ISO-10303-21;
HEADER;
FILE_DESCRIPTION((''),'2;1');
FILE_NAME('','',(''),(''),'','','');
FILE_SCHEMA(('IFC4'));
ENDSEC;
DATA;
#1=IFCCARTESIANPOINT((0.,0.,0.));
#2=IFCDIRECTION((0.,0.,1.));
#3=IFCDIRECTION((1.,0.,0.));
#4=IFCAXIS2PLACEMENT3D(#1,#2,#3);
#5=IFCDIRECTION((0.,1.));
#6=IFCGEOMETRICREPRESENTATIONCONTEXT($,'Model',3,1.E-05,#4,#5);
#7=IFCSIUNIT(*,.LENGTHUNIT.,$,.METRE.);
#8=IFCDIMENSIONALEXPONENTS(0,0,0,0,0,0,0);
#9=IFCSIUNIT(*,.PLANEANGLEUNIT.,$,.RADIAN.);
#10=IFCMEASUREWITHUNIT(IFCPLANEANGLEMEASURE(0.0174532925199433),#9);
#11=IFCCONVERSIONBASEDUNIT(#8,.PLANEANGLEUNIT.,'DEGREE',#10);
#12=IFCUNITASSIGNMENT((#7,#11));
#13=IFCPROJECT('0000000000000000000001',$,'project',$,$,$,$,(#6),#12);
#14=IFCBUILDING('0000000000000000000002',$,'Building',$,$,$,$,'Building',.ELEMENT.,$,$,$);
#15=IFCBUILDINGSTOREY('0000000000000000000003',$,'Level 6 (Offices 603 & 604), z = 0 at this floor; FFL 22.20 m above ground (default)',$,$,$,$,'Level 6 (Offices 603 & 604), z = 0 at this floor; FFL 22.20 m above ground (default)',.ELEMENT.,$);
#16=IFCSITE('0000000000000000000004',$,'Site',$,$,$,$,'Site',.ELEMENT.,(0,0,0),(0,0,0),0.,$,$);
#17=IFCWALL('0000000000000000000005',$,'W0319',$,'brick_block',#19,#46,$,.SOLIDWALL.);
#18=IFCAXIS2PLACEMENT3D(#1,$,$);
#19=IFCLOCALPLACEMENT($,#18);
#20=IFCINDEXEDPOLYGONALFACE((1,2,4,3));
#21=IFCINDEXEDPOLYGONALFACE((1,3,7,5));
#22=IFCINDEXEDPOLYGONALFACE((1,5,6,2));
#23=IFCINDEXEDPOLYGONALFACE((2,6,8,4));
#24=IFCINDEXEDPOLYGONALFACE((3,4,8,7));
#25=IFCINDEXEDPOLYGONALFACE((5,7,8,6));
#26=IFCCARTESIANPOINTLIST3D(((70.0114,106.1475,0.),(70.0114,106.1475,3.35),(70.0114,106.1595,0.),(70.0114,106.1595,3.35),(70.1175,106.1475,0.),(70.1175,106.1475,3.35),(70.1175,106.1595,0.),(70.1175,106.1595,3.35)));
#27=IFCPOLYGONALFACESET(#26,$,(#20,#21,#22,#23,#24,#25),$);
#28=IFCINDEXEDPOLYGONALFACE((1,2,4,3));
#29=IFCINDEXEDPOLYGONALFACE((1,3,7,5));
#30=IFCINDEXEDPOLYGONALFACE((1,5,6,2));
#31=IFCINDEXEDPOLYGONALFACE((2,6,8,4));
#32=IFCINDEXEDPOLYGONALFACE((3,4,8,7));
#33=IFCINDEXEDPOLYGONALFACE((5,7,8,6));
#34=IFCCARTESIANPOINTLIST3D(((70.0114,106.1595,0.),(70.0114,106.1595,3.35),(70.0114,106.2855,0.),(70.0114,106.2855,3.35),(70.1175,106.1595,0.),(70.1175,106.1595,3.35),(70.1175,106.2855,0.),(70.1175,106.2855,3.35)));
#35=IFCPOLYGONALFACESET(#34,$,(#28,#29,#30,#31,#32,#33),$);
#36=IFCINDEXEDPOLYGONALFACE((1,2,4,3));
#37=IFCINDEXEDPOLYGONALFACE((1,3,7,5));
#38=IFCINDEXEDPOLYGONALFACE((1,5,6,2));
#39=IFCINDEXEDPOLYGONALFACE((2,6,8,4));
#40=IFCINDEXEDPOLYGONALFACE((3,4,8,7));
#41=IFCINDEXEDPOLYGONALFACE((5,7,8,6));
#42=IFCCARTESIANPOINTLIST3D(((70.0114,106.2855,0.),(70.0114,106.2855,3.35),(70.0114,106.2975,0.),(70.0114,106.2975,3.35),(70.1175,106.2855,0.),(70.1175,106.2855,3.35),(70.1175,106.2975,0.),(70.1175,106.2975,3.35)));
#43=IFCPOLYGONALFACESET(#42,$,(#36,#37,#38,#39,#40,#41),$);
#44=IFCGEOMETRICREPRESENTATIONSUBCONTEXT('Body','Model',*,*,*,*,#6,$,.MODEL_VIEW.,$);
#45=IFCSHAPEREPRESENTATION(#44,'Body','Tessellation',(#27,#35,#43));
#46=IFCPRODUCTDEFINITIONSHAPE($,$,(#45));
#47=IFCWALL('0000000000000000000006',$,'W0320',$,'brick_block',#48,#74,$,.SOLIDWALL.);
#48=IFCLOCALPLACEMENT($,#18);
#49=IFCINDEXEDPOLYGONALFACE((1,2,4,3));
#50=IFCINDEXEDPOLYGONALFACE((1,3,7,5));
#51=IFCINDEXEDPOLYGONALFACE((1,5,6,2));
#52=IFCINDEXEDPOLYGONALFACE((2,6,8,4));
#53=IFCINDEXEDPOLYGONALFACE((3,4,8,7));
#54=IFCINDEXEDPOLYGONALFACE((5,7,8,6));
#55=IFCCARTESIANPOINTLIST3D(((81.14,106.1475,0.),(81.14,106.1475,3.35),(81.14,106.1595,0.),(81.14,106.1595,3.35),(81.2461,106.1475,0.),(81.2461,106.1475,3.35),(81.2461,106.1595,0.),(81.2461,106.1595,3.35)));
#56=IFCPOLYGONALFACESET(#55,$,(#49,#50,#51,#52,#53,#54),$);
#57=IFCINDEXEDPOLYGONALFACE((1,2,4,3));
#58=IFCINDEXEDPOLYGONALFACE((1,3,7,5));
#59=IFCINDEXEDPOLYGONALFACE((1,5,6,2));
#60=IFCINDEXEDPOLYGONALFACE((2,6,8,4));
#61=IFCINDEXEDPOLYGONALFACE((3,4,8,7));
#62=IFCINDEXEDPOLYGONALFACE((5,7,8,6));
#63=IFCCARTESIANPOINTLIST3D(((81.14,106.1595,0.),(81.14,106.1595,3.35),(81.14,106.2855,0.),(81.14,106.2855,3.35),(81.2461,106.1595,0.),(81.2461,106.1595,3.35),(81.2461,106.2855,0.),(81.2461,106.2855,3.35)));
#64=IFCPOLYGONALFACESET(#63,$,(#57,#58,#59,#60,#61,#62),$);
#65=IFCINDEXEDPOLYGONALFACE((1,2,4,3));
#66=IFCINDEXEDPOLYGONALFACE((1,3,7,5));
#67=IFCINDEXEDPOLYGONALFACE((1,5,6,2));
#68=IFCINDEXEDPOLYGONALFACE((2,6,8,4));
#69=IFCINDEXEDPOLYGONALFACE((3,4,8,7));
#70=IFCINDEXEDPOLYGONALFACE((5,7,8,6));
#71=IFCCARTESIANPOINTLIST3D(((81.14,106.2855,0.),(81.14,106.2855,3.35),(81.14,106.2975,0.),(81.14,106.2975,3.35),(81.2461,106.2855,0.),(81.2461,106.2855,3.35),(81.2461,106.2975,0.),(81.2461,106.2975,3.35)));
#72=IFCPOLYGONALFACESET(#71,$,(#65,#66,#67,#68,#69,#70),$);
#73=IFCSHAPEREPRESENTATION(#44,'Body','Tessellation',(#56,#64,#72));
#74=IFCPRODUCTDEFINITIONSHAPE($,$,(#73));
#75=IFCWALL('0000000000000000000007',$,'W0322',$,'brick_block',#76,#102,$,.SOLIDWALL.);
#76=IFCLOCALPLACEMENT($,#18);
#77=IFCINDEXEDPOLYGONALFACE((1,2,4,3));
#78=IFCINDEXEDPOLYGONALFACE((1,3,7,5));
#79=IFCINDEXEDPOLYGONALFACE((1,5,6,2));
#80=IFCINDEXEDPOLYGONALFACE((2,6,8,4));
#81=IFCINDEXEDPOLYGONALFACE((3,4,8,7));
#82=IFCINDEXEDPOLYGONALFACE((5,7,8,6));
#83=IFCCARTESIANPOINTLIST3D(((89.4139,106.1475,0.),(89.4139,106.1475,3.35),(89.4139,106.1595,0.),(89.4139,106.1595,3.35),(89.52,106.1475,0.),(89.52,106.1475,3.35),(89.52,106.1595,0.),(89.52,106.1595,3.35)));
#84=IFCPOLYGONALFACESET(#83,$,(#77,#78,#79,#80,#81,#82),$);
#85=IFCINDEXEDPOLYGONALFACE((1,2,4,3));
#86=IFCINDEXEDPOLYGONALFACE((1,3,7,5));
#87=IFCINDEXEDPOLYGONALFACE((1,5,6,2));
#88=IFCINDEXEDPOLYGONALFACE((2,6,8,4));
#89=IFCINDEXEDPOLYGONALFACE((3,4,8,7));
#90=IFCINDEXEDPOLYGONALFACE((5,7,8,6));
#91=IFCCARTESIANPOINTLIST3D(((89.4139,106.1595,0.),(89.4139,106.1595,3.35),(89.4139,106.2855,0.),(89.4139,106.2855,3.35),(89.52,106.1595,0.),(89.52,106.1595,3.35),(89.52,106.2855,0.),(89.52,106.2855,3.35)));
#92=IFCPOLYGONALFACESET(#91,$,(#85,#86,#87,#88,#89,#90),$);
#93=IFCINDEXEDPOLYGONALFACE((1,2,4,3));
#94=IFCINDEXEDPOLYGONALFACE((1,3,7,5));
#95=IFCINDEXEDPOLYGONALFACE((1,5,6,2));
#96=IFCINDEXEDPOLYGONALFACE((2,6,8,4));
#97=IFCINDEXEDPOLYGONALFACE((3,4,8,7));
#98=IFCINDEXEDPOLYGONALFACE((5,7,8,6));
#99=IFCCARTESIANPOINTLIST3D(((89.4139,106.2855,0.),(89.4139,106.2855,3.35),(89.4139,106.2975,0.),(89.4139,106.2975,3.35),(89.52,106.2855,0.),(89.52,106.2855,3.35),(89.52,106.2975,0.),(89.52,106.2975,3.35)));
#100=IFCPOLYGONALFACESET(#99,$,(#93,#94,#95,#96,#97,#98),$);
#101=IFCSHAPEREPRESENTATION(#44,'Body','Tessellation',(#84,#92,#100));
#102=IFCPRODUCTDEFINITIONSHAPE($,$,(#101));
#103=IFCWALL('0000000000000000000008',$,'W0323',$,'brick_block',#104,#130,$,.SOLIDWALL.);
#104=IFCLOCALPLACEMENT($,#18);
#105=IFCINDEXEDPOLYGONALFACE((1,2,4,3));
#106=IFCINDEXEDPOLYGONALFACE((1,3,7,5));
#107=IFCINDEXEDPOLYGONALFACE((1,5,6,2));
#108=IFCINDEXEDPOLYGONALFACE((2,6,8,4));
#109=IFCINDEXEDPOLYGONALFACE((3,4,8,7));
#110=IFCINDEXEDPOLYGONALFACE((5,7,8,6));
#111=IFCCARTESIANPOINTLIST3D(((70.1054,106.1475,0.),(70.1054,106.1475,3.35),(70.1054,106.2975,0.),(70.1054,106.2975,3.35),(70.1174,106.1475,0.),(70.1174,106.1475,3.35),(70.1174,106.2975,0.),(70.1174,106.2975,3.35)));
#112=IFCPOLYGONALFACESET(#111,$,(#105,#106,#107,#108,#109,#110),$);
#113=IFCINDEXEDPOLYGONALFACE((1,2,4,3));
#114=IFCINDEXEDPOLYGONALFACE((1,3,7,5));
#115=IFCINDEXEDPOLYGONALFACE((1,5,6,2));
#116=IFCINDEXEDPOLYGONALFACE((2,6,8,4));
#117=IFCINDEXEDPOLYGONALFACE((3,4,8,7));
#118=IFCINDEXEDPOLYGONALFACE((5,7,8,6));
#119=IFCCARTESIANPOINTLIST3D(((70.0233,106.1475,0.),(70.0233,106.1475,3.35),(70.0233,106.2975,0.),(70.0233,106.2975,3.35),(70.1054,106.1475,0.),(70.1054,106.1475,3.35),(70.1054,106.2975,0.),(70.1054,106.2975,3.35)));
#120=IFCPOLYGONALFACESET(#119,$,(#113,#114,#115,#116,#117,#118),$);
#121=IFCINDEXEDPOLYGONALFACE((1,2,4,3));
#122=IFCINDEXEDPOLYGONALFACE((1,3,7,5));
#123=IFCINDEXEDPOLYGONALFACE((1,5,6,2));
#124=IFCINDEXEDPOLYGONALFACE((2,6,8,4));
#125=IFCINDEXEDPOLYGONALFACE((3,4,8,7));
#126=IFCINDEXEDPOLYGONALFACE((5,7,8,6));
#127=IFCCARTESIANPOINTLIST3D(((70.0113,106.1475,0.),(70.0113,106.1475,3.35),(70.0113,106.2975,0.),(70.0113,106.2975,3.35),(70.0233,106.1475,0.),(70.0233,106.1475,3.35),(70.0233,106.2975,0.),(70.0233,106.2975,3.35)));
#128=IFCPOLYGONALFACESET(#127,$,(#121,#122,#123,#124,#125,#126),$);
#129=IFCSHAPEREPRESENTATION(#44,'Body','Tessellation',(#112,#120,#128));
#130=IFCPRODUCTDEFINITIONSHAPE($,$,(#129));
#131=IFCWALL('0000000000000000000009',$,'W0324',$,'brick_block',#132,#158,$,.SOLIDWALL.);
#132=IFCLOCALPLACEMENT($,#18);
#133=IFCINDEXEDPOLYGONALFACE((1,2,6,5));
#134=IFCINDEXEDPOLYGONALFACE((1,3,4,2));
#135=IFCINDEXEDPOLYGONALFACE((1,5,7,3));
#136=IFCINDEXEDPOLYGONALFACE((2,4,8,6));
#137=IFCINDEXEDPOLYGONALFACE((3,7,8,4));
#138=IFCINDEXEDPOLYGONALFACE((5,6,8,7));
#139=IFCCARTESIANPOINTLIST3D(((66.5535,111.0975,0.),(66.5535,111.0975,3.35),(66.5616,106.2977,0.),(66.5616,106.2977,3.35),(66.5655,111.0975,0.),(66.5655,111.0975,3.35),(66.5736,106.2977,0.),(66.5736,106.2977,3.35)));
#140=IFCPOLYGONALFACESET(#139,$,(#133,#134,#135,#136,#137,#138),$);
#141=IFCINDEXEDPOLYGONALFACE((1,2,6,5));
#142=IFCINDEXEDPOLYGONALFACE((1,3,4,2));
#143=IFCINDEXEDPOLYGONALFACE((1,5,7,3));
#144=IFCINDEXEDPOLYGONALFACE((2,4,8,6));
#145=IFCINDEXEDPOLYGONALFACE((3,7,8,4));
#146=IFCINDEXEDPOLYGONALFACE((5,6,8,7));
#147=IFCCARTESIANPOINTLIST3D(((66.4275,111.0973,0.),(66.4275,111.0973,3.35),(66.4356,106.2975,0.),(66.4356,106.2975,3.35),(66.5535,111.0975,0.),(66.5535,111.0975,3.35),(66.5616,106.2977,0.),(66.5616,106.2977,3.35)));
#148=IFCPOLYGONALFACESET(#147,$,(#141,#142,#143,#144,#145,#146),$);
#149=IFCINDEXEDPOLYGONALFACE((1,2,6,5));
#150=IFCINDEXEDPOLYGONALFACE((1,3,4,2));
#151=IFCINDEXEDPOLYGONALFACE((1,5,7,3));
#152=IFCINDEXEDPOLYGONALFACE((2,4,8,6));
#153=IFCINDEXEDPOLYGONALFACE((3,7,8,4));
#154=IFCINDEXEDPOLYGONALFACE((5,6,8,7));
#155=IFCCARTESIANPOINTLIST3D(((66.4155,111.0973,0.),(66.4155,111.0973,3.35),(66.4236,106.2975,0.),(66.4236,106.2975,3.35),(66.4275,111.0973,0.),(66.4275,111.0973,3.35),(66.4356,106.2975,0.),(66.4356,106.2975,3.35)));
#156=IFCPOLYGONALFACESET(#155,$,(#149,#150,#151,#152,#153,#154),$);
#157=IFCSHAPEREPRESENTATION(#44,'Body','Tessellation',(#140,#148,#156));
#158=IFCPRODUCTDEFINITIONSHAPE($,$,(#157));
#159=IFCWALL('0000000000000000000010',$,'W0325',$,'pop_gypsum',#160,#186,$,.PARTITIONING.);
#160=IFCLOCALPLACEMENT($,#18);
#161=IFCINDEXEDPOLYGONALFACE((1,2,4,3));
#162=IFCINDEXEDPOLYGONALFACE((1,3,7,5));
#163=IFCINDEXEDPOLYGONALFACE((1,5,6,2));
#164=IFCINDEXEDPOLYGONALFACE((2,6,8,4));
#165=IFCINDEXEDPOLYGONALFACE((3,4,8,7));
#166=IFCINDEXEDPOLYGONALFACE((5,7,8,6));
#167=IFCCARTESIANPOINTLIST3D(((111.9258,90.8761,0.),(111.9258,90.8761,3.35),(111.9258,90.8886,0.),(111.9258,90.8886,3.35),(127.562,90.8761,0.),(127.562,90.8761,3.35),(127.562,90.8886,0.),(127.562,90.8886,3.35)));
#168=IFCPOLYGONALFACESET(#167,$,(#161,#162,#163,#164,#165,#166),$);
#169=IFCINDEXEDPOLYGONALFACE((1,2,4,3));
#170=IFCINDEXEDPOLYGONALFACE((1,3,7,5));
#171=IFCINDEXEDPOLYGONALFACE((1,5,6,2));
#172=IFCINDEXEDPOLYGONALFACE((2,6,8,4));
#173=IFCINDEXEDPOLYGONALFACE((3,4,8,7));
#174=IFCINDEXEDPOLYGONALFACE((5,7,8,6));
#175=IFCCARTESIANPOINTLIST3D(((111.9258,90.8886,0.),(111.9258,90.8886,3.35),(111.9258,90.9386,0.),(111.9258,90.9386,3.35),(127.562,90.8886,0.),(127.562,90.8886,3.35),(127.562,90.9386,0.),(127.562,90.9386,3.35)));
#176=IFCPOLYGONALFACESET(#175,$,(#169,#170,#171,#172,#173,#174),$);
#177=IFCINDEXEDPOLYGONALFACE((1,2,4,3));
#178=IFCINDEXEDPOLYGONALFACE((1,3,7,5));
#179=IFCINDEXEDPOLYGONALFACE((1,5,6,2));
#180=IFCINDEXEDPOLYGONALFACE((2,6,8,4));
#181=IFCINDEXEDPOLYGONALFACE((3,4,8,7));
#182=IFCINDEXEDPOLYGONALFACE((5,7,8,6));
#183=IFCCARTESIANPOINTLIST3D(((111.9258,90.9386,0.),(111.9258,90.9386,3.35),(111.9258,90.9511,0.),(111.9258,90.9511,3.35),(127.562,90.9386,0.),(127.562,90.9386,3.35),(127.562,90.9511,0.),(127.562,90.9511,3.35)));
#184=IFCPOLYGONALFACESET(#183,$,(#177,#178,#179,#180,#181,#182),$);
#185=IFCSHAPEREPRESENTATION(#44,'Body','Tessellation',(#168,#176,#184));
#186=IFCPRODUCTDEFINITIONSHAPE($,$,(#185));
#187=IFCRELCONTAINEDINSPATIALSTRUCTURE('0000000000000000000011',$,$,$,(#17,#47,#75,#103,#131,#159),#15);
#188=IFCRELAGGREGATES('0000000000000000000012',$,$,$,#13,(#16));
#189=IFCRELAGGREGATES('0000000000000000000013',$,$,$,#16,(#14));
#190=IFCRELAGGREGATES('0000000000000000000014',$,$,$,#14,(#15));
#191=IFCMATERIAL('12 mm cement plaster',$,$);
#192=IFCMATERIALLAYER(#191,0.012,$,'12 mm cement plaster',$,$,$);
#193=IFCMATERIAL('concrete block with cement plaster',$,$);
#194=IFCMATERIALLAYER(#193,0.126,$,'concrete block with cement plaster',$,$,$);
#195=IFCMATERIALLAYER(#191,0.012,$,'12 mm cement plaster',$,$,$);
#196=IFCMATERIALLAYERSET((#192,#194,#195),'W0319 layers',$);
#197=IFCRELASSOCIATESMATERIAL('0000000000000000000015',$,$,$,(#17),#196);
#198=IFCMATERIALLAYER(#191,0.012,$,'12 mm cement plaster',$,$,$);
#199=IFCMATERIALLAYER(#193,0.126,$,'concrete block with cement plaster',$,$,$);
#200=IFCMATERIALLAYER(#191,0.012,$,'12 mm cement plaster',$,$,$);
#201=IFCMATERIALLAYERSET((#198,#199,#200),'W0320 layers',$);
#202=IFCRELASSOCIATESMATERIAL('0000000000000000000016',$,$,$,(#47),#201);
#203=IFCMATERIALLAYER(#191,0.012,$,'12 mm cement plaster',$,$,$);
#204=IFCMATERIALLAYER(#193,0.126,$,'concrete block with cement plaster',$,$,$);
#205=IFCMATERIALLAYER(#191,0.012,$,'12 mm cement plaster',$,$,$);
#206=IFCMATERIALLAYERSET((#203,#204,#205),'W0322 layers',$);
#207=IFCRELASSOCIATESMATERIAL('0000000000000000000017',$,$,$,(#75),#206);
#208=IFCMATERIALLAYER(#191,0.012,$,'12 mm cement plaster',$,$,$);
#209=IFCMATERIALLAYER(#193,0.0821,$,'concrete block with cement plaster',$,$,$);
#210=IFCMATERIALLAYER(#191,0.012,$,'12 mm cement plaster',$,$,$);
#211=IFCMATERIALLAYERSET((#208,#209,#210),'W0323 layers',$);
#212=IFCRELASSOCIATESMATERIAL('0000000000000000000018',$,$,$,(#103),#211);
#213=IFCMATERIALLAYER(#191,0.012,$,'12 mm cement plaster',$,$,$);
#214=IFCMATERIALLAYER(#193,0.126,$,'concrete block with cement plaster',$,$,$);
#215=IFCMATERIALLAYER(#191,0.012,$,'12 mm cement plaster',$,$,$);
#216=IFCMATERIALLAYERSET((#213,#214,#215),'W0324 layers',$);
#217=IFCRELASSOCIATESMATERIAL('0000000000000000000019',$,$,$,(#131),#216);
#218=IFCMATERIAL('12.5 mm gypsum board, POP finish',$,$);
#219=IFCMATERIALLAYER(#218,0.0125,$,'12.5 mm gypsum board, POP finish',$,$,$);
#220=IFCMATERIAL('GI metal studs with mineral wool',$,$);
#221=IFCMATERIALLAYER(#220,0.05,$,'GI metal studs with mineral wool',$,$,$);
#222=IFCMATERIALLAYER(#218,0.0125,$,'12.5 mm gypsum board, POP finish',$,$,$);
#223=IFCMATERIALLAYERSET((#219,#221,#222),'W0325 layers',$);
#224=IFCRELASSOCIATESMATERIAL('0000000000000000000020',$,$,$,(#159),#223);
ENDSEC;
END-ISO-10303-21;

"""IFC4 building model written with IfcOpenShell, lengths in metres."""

from ifc_helpers import new_model, entity, si_unit, converted_unit, direction, frame, frame_2d, origin_with_axes, origin_2d_with_axis, place, context, subcontext, project, spatial, rectangle, extrude, material, layer, layer_set, layer_usage, element, save


model = new_model("IFC4")

# Units and contexts
model_context = context("Model", 3, precision=1e-05, world=origin_with_axes(), true_north=direction((0.0, 1.0)))
body_context = subcontext(model_context, "Body", "Model", "MODEL_VIEW")
ifc_project = project(units=[si_unit("LENGTHUNIT", "METRE"), converted_unit("PLANEANGLEUNIT", "DEGREE", entity("IfcPlaneAngleMeasure", 0.0174532925199433), si_unit("PLANEANGLEUNIT", "RADIAN"), dimensions=[0, 0, 0, 0, 0, 0, 0])], contexts=[model_context])

# Site, building, storey
site = spatial("IfcSite", under=ifc_project, Name="Site", LongName="Site", CompositionType="ELEMENT", RefLatitude=(0, 0, 0), RefLongitude=(0, 0, 0), RefElevation=0.0)
building = spatial("IfcBuilding", under=site, Name="Building", LongName="Building", CompositionType="ELEMENT")
storey = spatial("IfcBuildingStorey", under=building, Name="Level 6 (Offices 603 & 604), z = 0 at this floor; FFL 22.20 m above ground (default)", LongName="Level 6 (Offices 603 & 604), z = 0 at this floor; FFL 22.20 m above ground (default)", CompositionType="ELEMENT")

# Walls
placement = place(None, origin_with_axes())
ifc_material_1 = material(Name="12.5 mm gypsum board, POP finish")
ifc_material_2 = material(Name="GI metal studs with mineral wool")
ifc_material_3 = material(Name="12 mm cement plaster")
ifc_material_4 = material(Name="concrete block with cement plaster")
ifc_layer_1 = layer(ifc_material_3, 0.012, Name="12 mm cement plaster")
ifc_layer_2 = layer(ifc_material_4, 0.126, Name="concrete block with cement plaster")
ifc_layer_3 = layer(ifc_material_3, 0.012, Name="12 mm cement plaster")
ifc_layer_set_1 = layer_set([ifc_layer_1, ifc_layer_2, ifc_layer_3], Name="W0319 layers")
ifc_layer_usage_1 = layer_usage(ifc_layer_set_1, "AXIS2", "POSITIVE", -0.075)
element("IfcWall", 1, at=placement, inside=storey, material=ifc_layer_usage_1, Name="W0319", ObjectType="brick_block", PredefinedType="SOLIDWALL", context=body_context, shape_type="SweptSolid", body=[
    extrude(rectangle(XDim=0.1061, YDim=0.012, at=origin_2d_with_axis()), frame((70.0644, 106.1535, 0.0), z_axis=(0.0, 0.0, 1.0), x_axis=(1.0, 0.0, 0.0)), (0.0, 0.0, 1.0), 3.35),
    extrude(rectangle(XDim=0.1061, YDim=0.126, at=frame_2d((0.0, 0.069), x_axis=(1.0, 0.0))), frame((70.0644, 106.1535, 0.0), z_axis=(0.0, 0.0, 1.0), x_axis=(1.0, 0.0, 0.0)), (0.0, 0.0, 1.0), 3.35),
    extrude(rectangle(XDim=0.1061, YDim=0.012, at=frame_2d((0.0, 0.138), x_axis=(1.0, 0.0))), frame((70.0644, 106.1535, 0.0), z_axis=(0.0, 0.0, 1.0), x_axis=(1.0, 0.0, 0.0)), (0.0, 0.0, 1.0), 3.35),
])
ifc_layer_4 = layer(ifc_material_3, 0.012, Name="12 mm cement plaster")
ifc_layer_5 = layer(ifc_material_4, 0.126, Name="concrete block with cement plaster")
ifc_layer_6 = layer(ifc_material_3, 0.012, Name="12 mm cement plaster")
ifc_layer_set_2 = layer_set([ifc_layer_4, ifc_layer_5, ifc_layer_6], Name="W0320 layers")
ifc_layer_usage_2 = layer_usage(ifc_layer_set_2, "AXIS2", "POSITIVE", -0.075)
element("IfcWall", 2, at=placement, inside=storey, material=ifc_layer_usage_2, Name="W0320", ObjectType="brick_block", PredefinedType="SOLIDWALL", context=body_context, shape_type="SweptSolid", body=[
    extrude(rectangle(XDim=0.1061, YDim=0.012, at=origin_2d_with_axis()), frame((81.193, 106.1535, 0.0), z_axis=(0.0, 0.0, 1.0), x_axis=(1.0, 0.0, 0.0)), (0.0, 0.0, 1.0), 3.35),
    extrude(rectangle(XDim=0.1061, YDim=0.126, at=frame_2d((0.0, 0.069), x_axis=(1.0, 0.0))), frame((81.193, 106.1535, 0.0), z_axis=(0.0, 0.0, 1.0), x_axis=(1.0, 0.0, 0.0)), (0.0, 0.0, 1.0), 3.35),
    extrude(rectangle(XDim=0.1061, YDim=0.012, at=frame_2d((0.0, 0.138), x_axis=(1.0, 0.0))), frame((81.193, 106.1535, 0.0), z_axis=(0.0, 0.0, 1.0), x_axis=(1.0, 0.0, 0.0)), (0.0, 0.0, 1.0), 3.35),
])
ifc_layer_7 = layer(ifc_material_3, 0.012, Name="12 mm cement plaster")
ifc_layer_8 = layer(ifc_material_4, 0.126, Name="concrete block with cement plaster")
ifc_layer_9 = layer(ifc_material_3, 0.012, Name="12 mm cement plaster")
ifc_layer_set_3 = layer_set([ifc_layer_7, ifc_layer_8, ifc_layer_9], Name="W0322 layers")
ifc_layer_usage_3 = layer_usage(ifc_layer_set_3, "AXIS2", "POSITIVE", -0.075)
element("IfcWall", 3, at=placement, inside=storey, material=ifc_layer_usage_3, Name="W0322", ObjectType="brick_block", PredefinedType="SOLIDWALL", context=body_context, shape_type="SweptSolid", body=[
    extrude(rectangle(XDim=0.1061, YDim=0.012, at=origin_2d_with_axis()), frame((89.4669, 106.1535, 0.0), z_axis=(0.0, 0.0, 1.0), x_axis=(1.0, 0.0, 0.0)), (0.0, 0.0, 1.0), 3.35),
    extrude(rectangle(XDim=0.1061, YDim=0.126, at=frame_2d((0.0, 0.069), x_axis=(1.0, 0.0))), frame((89.4669, 106.1535, 0.0), z_axis=(0.0, 0.0, 1.0), x_axis=(1.0, 0.0, 0.0)), (0.0, 0.0, 1.0), 3.35),
    extrude(rectangle(XDim=0.1061, YDim=0.012, at=frame_2d((0.0, 0.138), x_axis=(1.0, 0.0))), frame((89.4669, 106.1535, 0.0), z_axis=(0.0, 0.0, 1.0), x_axis=(1.0, 0.0, 0.0)), (0.0, 0.0, 1.0), 3.35),
])
ifc_layer_10 = layer(ifc_material_3, 0.012, Name="12 mm cement plaster")
ifc_layer_11 = layer(ifc_material_4, 0.0821, Name="concrete block with cement plaster")
ifc_layer_12 = layer(ifc_material_3, 0.012, Name="12 mm cement plaster")
ifc_layer_set_4 = layer_set([ifc_layer_10, ifc_layer_11, ifc_layer_12], Name="W0323 layers")
ifc_layer_usage_4 = layer_usage(ifc_layer_set_4, "AXIS2", "POSITIVE", -0.053)
element("IfcWall", 4, at=placement, inside=storey, material=ifc_layer_usage_4, Name="W0323", ObjectType="brick_block", PredefinedType="SOLIDWALL", context=body_context, shape_type="SweptSolid", body=[
    extrude(rectangle(XDim=0.15, YDim=0.012, at=frame_2d((0.0, 0.0), x_axis=(0.0, 1.0))), frame((70.1115, 106.2225, 0.0), z_axis=(0.0, 0.0, 1.0), x_axis=(1.0, 0.0, 0.0)), (0.0, 0.0, 1.0), 3.35),
    extrude(rectangle(XDim=0.15, YDim=0.0821, at=frame_2d((-0.0471, 0.0), x_axis=(0.0, 1.0))), frame((70.1115, 106.2225, 0.0), z_axis=(0.0, 0.0, 1.0), x_axis=(1.0, 0.0, 0.0)), (0.0, 0.0, 1.0), 3.35),
    extrude(rectangle(XDim=0.15, YDim=0.012, at=frame_2d((-0.0941, 0.0), x_axis=(0.0, 1.0))), frame((70.1115, 106.2225, 0.0), z_axis=(0.0, 0.0, 1.0), x_axis=(1.0, 0.0, 0.0)), (0.0, 0.0, 1.0), 3.35),
])
ifc_layer_13 = layer(ifc_material_3, 0.012, Name="12 mm cement plaster")
ifc_layer_14 = layer(ifc_material_4, 0.126, Name="concrete block with cement plaster")
ifc_layer_15 = layer(ifc_material_3, 0.012, Name="12 mm cement plaster")
ifc_layer_set_5 = layer_set([ifc_layer_13, ifc_layer_14, ifc_layer_15], Name="W0324 layers")
ifc_layer_usage_5 = layer_usage(ifc_layer_set_5, "AXIS2", "POSITIVE", -0.075)
element("IfcWall", 5, at=placement, inside=storey, material=ifc_layer_usage_5, Name="W0324", ObjectType="brick_block", PredefinedType="SOLIDWALL", context=body_context, shape_type="SweptSolid", body=[
    extrude(rectangle(XDim=4.7998, YDim=0.012, at=frame_2d((0.0, 0.0), x_axis=(0.001688, -0.999999))), frame((66.5635, 108.6976, 0.0), z_axis=(0.0, 0.0, 1.0), x_axis=(1.0, 0.0, 0.0)), (0.0, 0.0, 1.0), 3.35),
    extrude(rectangle(XDim=4.7998, YDim=0.126, at=frame_2d((-0.069, -0.0001), x_axis=(0.001688, -0.999999))), frame((66.5635, 108.6976, 0.0), z_axis=(0.0, 0.0, 1.0), x_axis=(1.0, 0.0, 0.0)), (0.0, 0.0, 1.0), 3.35),
    extrude(rectangle(XDim=4.7998, YDim=0.012, at=frame_2d((-0.138, -0.0002), x_axis=(0.001688, -0.999999))), frame((66.5635, 108.6976, 0.0), z_axis=(0.0, 0.0, 1.0), x_axis=(1.0, 0.0, 0.0)), (0.0, 0.0, 1.0), 3.35),
])
ifc_layer_16 = layer(ifc_material_1, 0.0125, Name="12.5 mm gypsum board, POP finish")
ifc_layer_17 = layer(ifc_material_2, 0.05, Name="GI metal studs with mineral wool")
ifc_layer_18 = layer(ifc_material_1, 0.0125, Name="12.5 mm gypsum board, POP finish")
ifc_layer_set_6 = layer_set([ifc_layer_16, ifc_layer_17, ifc_layer_18], Name="W0325 layers")
ifc_layer_usage_6 = layer_usage(ifc_layer_set_6, "AXIS2", "POSITIVE", -0.0375)
element("IfcWall", 6, at=placement, inside=storey, material=ifc_layer_usage_6, Name="W0325", ObjectType="pop_gypsum", PredefinedType="PARTITIONING", context=body_context, shape_type="SweptSolid", body=[
    extrude(rectangle(XDim=15.6362, YDim=0.0125, at=origin_2d_with_axis()), frame((119.7439, 90.8824, 0.0), z_axis=(0.0, 0.0, 1.0), x_axis=(1.0, 0.0, 0.0)), (0.0, 0.0, 1.0), 3.35),
    extrude(rectangle(XDim=15.6362, YDim=0.05, at=frame_2d((0.0, 0.0312), x_axis=(1.0, 0.0))), frame((119.7439, 90.8824, 0.0), z_axis=(0.0, 0.0, 1.0), x_axis=(1.0, 0.0, 0.0)), (0.0, 0.0, 1.0), 3.35),
    extrude(rectangle(XDim=15.6362, YDim=0.0125, at=frame_2d((0.0, 0.0625), x_axis=(1.0, 0.0))), frame((119.7439, 90.8824, 0.0), z_axis=(0.0, 0.0, 1.0), x_axis=(1.0, 0.0, 0.0)), (0.0, 0.0, 1.0), 3.35),
])

save(model, "model.ifc")
